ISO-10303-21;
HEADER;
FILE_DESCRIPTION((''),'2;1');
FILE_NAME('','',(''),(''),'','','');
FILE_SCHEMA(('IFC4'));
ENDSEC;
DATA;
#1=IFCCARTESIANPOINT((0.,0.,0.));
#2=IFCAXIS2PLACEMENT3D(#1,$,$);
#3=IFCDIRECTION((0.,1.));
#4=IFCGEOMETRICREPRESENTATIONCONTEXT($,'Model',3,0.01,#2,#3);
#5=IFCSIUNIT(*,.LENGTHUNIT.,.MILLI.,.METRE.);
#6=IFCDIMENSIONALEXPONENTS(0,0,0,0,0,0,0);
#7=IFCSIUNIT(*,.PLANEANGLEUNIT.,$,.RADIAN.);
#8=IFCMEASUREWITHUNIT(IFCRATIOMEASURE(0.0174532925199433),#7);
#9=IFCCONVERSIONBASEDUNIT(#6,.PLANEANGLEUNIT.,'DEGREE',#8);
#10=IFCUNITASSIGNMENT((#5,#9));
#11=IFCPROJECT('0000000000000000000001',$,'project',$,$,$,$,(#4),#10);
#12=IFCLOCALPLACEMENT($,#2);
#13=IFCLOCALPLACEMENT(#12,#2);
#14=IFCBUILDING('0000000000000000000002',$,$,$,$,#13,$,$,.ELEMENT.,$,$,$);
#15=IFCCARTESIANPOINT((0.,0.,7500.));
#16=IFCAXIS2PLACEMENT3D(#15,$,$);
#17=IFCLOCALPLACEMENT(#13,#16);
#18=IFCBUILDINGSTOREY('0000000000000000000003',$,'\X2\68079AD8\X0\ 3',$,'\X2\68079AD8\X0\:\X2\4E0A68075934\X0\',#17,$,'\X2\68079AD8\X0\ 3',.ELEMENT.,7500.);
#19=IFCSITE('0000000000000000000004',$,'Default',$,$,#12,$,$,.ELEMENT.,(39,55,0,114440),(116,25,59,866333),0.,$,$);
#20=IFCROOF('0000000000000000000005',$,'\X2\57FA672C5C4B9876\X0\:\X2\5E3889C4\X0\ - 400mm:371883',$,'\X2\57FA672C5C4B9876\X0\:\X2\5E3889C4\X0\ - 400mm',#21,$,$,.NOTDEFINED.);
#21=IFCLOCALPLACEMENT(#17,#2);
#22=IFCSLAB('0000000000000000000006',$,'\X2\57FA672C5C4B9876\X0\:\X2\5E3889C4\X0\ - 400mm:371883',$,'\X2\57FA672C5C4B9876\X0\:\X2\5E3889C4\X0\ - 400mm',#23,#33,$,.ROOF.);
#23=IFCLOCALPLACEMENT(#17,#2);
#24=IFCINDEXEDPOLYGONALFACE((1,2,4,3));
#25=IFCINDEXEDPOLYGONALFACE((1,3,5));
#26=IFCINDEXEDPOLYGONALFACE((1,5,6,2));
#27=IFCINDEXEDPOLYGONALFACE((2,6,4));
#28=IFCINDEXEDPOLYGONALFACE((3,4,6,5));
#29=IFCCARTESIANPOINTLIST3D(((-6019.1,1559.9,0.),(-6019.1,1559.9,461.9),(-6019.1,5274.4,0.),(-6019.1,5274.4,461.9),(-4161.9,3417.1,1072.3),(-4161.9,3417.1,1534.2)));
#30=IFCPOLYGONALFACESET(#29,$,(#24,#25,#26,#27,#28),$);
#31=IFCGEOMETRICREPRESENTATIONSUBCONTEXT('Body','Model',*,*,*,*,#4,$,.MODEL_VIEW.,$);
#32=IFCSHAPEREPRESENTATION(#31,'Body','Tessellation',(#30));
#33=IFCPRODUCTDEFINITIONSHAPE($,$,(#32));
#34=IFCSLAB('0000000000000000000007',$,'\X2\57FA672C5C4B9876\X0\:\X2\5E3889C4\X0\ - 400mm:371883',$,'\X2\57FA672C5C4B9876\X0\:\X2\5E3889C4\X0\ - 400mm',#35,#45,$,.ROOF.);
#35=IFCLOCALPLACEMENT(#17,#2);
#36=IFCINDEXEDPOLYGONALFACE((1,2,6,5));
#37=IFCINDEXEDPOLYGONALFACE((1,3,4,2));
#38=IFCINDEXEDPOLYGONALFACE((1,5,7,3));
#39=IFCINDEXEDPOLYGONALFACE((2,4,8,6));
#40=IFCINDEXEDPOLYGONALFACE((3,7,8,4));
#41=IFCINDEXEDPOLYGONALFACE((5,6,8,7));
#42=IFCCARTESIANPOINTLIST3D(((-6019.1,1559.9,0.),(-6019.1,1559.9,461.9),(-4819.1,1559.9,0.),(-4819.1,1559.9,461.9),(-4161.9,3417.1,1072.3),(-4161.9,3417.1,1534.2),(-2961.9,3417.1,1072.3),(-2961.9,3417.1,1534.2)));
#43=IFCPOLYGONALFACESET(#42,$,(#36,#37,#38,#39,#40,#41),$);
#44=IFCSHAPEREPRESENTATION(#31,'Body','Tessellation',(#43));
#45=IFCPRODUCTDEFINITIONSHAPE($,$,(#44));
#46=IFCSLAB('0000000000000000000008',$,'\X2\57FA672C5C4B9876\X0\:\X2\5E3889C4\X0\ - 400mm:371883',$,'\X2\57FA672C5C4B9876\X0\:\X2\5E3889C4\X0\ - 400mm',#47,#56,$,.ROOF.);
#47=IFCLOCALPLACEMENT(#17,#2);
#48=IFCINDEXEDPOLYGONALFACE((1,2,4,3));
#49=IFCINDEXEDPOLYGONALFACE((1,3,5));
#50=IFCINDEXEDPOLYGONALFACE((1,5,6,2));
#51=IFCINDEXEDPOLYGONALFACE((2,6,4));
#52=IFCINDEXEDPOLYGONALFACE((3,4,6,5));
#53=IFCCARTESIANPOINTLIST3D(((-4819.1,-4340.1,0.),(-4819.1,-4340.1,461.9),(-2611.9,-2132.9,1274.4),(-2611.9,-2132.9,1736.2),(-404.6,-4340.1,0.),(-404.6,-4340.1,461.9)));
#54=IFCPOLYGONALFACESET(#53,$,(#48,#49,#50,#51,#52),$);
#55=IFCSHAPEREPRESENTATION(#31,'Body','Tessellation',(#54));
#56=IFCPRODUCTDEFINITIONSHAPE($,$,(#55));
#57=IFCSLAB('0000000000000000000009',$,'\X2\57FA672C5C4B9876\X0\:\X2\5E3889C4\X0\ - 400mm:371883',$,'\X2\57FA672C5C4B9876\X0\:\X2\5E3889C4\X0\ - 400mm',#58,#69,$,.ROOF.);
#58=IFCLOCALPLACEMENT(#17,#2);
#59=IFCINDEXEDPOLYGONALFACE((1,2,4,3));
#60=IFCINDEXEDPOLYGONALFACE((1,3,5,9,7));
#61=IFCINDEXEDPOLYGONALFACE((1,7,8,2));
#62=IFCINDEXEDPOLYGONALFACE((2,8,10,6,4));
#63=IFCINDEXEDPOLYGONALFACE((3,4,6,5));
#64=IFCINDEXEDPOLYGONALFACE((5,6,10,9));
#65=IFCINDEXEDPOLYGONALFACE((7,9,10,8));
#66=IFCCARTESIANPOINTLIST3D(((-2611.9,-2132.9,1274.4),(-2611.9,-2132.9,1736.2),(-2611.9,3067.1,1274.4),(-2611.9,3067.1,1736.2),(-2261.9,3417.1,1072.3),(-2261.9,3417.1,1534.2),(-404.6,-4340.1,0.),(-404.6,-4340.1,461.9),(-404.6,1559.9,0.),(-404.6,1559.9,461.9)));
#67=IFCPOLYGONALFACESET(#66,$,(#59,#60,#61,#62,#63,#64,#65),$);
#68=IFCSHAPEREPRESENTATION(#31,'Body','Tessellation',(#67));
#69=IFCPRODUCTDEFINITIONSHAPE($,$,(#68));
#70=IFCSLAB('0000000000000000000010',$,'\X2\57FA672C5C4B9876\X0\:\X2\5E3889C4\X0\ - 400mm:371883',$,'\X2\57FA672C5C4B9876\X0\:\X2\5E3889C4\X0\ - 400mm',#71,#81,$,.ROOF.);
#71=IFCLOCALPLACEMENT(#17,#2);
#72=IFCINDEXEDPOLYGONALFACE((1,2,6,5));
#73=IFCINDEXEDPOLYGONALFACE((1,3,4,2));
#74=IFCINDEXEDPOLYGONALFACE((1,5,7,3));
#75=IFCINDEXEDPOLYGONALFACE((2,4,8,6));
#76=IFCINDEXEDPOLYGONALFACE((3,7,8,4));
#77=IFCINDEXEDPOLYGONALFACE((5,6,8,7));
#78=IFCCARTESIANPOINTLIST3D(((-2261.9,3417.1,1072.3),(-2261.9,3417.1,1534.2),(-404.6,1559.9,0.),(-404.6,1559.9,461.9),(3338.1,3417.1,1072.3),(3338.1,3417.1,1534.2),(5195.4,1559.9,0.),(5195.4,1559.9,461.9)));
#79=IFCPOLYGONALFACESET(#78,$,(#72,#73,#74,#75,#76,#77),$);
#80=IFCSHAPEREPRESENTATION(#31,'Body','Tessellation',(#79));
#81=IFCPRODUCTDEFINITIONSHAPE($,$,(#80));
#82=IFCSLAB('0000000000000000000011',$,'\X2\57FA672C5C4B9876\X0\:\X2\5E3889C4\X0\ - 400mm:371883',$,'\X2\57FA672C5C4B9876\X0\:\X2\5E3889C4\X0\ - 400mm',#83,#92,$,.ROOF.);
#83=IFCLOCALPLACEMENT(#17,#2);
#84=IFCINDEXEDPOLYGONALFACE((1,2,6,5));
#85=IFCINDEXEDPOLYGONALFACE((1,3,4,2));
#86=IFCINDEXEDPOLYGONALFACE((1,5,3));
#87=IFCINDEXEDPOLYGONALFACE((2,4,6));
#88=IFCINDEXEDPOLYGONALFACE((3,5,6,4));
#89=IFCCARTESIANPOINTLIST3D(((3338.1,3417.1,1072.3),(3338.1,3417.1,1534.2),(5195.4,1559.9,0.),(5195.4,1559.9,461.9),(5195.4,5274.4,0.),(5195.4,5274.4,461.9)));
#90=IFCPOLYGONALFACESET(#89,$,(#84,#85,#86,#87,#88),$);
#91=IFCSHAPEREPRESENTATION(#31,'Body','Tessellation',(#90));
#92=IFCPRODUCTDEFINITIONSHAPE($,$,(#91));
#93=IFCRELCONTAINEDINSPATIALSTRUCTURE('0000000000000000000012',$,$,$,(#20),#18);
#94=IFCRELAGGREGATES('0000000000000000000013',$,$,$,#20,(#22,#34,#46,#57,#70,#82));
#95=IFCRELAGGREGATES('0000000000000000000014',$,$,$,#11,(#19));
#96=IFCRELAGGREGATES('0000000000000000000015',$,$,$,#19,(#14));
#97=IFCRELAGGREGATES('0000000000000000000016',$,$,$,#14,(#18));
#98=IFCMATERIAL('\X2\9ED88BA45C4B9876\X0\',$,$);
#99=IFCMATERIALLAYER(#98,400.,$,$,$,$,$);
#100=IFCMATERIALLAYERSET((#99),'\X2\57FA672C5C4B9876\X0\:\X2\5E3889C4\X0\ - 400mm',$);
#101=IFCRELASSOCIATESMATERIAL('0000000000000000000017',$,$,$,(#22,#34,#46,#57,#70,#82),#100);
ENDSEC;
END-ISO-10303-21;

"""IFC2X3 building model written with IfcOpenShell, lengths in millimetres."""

from ifc_helpers import new_model, entity, si_unit, converted_unit, direction, frame, origin, place, context, subcontext, project, spatial, polyline, outline, extrude, material, layer, layer_set, element, aggregate, save


model = new_model("IFC2X3")

# Units and contexts
model_context = context("Model", 3, precision=0.01, world=origin(), true_north=direction((0.0, 1.0)))
body_context = subcontext(model_context, "Body", "Model", "MODEL_VIEW")
ifc_project = project(units=[si_unit("LENGTHUNIT", "METRE", prefix="MILLI"), converted_unit("PLANEANGLEUNIT", "DEGREE", entity("IfcRatioMeasure", 0.0174532925199433), si_unit("PLANEANGLEUNIT", "RADIAN"), dimensions=[0, 0, 0, 0, 0, 0, 0])], contexts=[model_context])

# Site, building, storey
site_placement = place(None, origin())
site = spatial("IfcSite", under=ifc_project, at=site_placement, Name="Default", CompositionType="ELEMENT", RefLatitude=(39, 55, 0, 114440), RefLongitude=(116, 25, 59, 866333), RefElevation=0.0)
building_placement = place(site_placement, origin())
building = spatial("IfcBuilding", under=site, at=building_placement, CompositionType="ELEMENT")
storey_placement = place(building_placement, frame((0.0, 0.0, 7500.0)))
storey = spatial("IfcBuildingStorey", under=building, at=storey_placement, Name="标高 3", ObjectType="标高:上标头", LongName="标高 3", CompositionType="ELEMENT", Elevation=7500.0)

# Roof, slabs
roof_placement = place(storey_placement, frame((-6019.1, -4340.1, 0.0)))
roof = element("IfcRoof", 1, at=roof_placement, inside=storey, Name="基本屋顶:常规 - 400mm:371883", ObjectType="基本屋顶:常规 - 400mm", ShapeType="NOTDEFINED")
ifc_material = material(Name="默认屋顶")
ifc_layer = layer(ifc_material, 400.0)
ifc_layer_set = layer_set([ifc_layer], Name="基本屋顶:常规 - 400mm")
slab_1_placement = place(roof_placement, origin())
slab_1 = element("IfcSlab", 2, at=slab_1_placement, material=ifc_layer_set, Name="基本屋顶:常规 - 400mm:371883", ObjectType="基本屋顶:常规 - 400mm", PredefinedType="ROOF", context=body_context, shape_type="SweptSolid", body=[
    extrude(outline(polyline([(-1072.3, 1857.2), (-1072.3, -1857.2), (1072.3, 0.0), (-1072.3, 1857.2)])), frame((928.6, 7757.3, 536.1), z_axis=(-0.5, 0.0, 0.866025), x_axis=(0.866025, 0.0, 0.5)), (0.5, 0.0, 0.866025), 461.9),
])
slab_2_placement = place(roof_placement, origin())
slab_2 = element("IfcSlab", 3, at=slab_2_placement, material=ifc_layer_set, Name="基本屋顶:常规 - 400mm:371883", ObjectType="基本屋顶:常规 - 400mm", PredefinedType="ROOF", context=body_context, shape_type="SweptSolid", body=[
    extrude(outline(polyline([(-328.6, -1072.3), (1528.6, 1072.3), (328.6, 1072.3), (-1528.6, -1072.3), (-328.6, -1072.3)])), frame((1528.6, 6828.6, 536.1), z_axis=(0.0, -0.5, 0.866025), x_axis=(1.0, 0.0, 0.0)), (0.0, 0.5, 0.866025), 461.9),
])
slab_3_placement = place(roof_placement, origin())
slab_3 = element("IfcSlab", 4, at=slab_3_placement, material=ifc_layer_set, Name="基本屋顶:常规 - 400mm:371883", ObjectType="基本屋顶:常规 - 400mm", PredefinedType="ROOF", context=body_context, shape_type="SweptSolid", body=[
    extrude(outline(polyline([(-2207.2, -1274.4), (2207.2, -1274.4), (0.0, 1274.4), (-2207.2, -1274.4)])), frame((3407.2, 1103.6, 637.2), z_axis=(0.0, -0.5, 0.866025), x_axis=(1.0, 0.0, 0.0)), (0.0, 0.5, 0.866025), 461.9),
])
slab_4_placement = place(roof_placement, origin())
slab_4 = element("IfcSlab", 5, at=slab_4_placement, material=ifc_layer_set, Name="基本屋顶:常规 - 400mm:371883", ObjectType="基本屋顶:常规 - 400mm", PredefinedType="ROOF", context=body_context, shape_type="SweptSolid", body=[
    extrude(outline(polyline([(1274.4, -3878.6), (1274.4, 2021.4), (-870.2, 3878.6), (-1274.4, 3528.6), (-1274.4, -1671.4), (1274.4, -3878.6)])), frame((4510.9, 3878.6, 637.2), z_axis=(0.5, 0.0, 0.866025), x_axis=(0.866025, 0.0, -0.5)), (-0.5, 0.0, 0.866025), 461.9),
])
slab_5_placement = place(roof_placement, origin())
slab_5 = element("IfcSlab", 6, at=slab_5_placement, material=ifc_layer_set, Name="基本屋顶:常规 - 400mm:371883", ObjectType="基本屋顶:常规 - 400mm", PredefinedType="ROOF", context=body_context, shape_type="SweptSolid", body=[
    extrude(outline(polyline([(-1871.4, -1072.3), (3728.6, -1072.3), (1871.4, 1072.3), (-3728.6, 1072.3), (-1871.4, -1072.3)])), frame((7485.9, 6828.6, 536.1), z_axis=(0.0, -0.5, 0.866025), x_axis=(1.0, 0.0, 0.0)), (0.0, 0.5, 0.866025), 461.9),
])
slab_6_placement = place(roof_placement, origin())
slab_6 = element("IfcSlab", 7, at=slab_6_placement, material=ifc_layer_set, Name="基本屋顶:常规 - 400mm:371883", ObjectType="基本屋顶:常规 - 400mm", PredefinedType="ROOF", context=body_context, shape_type="SweptSolid", body=[
    extrude(outline(polyline([(-1072.3, 0.0), (1072.3, -1857.2), (1072.3, 1857.2), (-1072.3, 0.0)])), frame((10285.9, 7757.2, 536.1), z_axis=(0.5, 0.0, 0.866025), x_axis=(0.866025, 0.0, -0.5)), (-0.5, 0.0, 0.866025), 461.9),
])
aggregate(roof, [slab_1, slab_2, slab_3, slab_4, slab_5, slab_6])

save(model, "model.ifc")
